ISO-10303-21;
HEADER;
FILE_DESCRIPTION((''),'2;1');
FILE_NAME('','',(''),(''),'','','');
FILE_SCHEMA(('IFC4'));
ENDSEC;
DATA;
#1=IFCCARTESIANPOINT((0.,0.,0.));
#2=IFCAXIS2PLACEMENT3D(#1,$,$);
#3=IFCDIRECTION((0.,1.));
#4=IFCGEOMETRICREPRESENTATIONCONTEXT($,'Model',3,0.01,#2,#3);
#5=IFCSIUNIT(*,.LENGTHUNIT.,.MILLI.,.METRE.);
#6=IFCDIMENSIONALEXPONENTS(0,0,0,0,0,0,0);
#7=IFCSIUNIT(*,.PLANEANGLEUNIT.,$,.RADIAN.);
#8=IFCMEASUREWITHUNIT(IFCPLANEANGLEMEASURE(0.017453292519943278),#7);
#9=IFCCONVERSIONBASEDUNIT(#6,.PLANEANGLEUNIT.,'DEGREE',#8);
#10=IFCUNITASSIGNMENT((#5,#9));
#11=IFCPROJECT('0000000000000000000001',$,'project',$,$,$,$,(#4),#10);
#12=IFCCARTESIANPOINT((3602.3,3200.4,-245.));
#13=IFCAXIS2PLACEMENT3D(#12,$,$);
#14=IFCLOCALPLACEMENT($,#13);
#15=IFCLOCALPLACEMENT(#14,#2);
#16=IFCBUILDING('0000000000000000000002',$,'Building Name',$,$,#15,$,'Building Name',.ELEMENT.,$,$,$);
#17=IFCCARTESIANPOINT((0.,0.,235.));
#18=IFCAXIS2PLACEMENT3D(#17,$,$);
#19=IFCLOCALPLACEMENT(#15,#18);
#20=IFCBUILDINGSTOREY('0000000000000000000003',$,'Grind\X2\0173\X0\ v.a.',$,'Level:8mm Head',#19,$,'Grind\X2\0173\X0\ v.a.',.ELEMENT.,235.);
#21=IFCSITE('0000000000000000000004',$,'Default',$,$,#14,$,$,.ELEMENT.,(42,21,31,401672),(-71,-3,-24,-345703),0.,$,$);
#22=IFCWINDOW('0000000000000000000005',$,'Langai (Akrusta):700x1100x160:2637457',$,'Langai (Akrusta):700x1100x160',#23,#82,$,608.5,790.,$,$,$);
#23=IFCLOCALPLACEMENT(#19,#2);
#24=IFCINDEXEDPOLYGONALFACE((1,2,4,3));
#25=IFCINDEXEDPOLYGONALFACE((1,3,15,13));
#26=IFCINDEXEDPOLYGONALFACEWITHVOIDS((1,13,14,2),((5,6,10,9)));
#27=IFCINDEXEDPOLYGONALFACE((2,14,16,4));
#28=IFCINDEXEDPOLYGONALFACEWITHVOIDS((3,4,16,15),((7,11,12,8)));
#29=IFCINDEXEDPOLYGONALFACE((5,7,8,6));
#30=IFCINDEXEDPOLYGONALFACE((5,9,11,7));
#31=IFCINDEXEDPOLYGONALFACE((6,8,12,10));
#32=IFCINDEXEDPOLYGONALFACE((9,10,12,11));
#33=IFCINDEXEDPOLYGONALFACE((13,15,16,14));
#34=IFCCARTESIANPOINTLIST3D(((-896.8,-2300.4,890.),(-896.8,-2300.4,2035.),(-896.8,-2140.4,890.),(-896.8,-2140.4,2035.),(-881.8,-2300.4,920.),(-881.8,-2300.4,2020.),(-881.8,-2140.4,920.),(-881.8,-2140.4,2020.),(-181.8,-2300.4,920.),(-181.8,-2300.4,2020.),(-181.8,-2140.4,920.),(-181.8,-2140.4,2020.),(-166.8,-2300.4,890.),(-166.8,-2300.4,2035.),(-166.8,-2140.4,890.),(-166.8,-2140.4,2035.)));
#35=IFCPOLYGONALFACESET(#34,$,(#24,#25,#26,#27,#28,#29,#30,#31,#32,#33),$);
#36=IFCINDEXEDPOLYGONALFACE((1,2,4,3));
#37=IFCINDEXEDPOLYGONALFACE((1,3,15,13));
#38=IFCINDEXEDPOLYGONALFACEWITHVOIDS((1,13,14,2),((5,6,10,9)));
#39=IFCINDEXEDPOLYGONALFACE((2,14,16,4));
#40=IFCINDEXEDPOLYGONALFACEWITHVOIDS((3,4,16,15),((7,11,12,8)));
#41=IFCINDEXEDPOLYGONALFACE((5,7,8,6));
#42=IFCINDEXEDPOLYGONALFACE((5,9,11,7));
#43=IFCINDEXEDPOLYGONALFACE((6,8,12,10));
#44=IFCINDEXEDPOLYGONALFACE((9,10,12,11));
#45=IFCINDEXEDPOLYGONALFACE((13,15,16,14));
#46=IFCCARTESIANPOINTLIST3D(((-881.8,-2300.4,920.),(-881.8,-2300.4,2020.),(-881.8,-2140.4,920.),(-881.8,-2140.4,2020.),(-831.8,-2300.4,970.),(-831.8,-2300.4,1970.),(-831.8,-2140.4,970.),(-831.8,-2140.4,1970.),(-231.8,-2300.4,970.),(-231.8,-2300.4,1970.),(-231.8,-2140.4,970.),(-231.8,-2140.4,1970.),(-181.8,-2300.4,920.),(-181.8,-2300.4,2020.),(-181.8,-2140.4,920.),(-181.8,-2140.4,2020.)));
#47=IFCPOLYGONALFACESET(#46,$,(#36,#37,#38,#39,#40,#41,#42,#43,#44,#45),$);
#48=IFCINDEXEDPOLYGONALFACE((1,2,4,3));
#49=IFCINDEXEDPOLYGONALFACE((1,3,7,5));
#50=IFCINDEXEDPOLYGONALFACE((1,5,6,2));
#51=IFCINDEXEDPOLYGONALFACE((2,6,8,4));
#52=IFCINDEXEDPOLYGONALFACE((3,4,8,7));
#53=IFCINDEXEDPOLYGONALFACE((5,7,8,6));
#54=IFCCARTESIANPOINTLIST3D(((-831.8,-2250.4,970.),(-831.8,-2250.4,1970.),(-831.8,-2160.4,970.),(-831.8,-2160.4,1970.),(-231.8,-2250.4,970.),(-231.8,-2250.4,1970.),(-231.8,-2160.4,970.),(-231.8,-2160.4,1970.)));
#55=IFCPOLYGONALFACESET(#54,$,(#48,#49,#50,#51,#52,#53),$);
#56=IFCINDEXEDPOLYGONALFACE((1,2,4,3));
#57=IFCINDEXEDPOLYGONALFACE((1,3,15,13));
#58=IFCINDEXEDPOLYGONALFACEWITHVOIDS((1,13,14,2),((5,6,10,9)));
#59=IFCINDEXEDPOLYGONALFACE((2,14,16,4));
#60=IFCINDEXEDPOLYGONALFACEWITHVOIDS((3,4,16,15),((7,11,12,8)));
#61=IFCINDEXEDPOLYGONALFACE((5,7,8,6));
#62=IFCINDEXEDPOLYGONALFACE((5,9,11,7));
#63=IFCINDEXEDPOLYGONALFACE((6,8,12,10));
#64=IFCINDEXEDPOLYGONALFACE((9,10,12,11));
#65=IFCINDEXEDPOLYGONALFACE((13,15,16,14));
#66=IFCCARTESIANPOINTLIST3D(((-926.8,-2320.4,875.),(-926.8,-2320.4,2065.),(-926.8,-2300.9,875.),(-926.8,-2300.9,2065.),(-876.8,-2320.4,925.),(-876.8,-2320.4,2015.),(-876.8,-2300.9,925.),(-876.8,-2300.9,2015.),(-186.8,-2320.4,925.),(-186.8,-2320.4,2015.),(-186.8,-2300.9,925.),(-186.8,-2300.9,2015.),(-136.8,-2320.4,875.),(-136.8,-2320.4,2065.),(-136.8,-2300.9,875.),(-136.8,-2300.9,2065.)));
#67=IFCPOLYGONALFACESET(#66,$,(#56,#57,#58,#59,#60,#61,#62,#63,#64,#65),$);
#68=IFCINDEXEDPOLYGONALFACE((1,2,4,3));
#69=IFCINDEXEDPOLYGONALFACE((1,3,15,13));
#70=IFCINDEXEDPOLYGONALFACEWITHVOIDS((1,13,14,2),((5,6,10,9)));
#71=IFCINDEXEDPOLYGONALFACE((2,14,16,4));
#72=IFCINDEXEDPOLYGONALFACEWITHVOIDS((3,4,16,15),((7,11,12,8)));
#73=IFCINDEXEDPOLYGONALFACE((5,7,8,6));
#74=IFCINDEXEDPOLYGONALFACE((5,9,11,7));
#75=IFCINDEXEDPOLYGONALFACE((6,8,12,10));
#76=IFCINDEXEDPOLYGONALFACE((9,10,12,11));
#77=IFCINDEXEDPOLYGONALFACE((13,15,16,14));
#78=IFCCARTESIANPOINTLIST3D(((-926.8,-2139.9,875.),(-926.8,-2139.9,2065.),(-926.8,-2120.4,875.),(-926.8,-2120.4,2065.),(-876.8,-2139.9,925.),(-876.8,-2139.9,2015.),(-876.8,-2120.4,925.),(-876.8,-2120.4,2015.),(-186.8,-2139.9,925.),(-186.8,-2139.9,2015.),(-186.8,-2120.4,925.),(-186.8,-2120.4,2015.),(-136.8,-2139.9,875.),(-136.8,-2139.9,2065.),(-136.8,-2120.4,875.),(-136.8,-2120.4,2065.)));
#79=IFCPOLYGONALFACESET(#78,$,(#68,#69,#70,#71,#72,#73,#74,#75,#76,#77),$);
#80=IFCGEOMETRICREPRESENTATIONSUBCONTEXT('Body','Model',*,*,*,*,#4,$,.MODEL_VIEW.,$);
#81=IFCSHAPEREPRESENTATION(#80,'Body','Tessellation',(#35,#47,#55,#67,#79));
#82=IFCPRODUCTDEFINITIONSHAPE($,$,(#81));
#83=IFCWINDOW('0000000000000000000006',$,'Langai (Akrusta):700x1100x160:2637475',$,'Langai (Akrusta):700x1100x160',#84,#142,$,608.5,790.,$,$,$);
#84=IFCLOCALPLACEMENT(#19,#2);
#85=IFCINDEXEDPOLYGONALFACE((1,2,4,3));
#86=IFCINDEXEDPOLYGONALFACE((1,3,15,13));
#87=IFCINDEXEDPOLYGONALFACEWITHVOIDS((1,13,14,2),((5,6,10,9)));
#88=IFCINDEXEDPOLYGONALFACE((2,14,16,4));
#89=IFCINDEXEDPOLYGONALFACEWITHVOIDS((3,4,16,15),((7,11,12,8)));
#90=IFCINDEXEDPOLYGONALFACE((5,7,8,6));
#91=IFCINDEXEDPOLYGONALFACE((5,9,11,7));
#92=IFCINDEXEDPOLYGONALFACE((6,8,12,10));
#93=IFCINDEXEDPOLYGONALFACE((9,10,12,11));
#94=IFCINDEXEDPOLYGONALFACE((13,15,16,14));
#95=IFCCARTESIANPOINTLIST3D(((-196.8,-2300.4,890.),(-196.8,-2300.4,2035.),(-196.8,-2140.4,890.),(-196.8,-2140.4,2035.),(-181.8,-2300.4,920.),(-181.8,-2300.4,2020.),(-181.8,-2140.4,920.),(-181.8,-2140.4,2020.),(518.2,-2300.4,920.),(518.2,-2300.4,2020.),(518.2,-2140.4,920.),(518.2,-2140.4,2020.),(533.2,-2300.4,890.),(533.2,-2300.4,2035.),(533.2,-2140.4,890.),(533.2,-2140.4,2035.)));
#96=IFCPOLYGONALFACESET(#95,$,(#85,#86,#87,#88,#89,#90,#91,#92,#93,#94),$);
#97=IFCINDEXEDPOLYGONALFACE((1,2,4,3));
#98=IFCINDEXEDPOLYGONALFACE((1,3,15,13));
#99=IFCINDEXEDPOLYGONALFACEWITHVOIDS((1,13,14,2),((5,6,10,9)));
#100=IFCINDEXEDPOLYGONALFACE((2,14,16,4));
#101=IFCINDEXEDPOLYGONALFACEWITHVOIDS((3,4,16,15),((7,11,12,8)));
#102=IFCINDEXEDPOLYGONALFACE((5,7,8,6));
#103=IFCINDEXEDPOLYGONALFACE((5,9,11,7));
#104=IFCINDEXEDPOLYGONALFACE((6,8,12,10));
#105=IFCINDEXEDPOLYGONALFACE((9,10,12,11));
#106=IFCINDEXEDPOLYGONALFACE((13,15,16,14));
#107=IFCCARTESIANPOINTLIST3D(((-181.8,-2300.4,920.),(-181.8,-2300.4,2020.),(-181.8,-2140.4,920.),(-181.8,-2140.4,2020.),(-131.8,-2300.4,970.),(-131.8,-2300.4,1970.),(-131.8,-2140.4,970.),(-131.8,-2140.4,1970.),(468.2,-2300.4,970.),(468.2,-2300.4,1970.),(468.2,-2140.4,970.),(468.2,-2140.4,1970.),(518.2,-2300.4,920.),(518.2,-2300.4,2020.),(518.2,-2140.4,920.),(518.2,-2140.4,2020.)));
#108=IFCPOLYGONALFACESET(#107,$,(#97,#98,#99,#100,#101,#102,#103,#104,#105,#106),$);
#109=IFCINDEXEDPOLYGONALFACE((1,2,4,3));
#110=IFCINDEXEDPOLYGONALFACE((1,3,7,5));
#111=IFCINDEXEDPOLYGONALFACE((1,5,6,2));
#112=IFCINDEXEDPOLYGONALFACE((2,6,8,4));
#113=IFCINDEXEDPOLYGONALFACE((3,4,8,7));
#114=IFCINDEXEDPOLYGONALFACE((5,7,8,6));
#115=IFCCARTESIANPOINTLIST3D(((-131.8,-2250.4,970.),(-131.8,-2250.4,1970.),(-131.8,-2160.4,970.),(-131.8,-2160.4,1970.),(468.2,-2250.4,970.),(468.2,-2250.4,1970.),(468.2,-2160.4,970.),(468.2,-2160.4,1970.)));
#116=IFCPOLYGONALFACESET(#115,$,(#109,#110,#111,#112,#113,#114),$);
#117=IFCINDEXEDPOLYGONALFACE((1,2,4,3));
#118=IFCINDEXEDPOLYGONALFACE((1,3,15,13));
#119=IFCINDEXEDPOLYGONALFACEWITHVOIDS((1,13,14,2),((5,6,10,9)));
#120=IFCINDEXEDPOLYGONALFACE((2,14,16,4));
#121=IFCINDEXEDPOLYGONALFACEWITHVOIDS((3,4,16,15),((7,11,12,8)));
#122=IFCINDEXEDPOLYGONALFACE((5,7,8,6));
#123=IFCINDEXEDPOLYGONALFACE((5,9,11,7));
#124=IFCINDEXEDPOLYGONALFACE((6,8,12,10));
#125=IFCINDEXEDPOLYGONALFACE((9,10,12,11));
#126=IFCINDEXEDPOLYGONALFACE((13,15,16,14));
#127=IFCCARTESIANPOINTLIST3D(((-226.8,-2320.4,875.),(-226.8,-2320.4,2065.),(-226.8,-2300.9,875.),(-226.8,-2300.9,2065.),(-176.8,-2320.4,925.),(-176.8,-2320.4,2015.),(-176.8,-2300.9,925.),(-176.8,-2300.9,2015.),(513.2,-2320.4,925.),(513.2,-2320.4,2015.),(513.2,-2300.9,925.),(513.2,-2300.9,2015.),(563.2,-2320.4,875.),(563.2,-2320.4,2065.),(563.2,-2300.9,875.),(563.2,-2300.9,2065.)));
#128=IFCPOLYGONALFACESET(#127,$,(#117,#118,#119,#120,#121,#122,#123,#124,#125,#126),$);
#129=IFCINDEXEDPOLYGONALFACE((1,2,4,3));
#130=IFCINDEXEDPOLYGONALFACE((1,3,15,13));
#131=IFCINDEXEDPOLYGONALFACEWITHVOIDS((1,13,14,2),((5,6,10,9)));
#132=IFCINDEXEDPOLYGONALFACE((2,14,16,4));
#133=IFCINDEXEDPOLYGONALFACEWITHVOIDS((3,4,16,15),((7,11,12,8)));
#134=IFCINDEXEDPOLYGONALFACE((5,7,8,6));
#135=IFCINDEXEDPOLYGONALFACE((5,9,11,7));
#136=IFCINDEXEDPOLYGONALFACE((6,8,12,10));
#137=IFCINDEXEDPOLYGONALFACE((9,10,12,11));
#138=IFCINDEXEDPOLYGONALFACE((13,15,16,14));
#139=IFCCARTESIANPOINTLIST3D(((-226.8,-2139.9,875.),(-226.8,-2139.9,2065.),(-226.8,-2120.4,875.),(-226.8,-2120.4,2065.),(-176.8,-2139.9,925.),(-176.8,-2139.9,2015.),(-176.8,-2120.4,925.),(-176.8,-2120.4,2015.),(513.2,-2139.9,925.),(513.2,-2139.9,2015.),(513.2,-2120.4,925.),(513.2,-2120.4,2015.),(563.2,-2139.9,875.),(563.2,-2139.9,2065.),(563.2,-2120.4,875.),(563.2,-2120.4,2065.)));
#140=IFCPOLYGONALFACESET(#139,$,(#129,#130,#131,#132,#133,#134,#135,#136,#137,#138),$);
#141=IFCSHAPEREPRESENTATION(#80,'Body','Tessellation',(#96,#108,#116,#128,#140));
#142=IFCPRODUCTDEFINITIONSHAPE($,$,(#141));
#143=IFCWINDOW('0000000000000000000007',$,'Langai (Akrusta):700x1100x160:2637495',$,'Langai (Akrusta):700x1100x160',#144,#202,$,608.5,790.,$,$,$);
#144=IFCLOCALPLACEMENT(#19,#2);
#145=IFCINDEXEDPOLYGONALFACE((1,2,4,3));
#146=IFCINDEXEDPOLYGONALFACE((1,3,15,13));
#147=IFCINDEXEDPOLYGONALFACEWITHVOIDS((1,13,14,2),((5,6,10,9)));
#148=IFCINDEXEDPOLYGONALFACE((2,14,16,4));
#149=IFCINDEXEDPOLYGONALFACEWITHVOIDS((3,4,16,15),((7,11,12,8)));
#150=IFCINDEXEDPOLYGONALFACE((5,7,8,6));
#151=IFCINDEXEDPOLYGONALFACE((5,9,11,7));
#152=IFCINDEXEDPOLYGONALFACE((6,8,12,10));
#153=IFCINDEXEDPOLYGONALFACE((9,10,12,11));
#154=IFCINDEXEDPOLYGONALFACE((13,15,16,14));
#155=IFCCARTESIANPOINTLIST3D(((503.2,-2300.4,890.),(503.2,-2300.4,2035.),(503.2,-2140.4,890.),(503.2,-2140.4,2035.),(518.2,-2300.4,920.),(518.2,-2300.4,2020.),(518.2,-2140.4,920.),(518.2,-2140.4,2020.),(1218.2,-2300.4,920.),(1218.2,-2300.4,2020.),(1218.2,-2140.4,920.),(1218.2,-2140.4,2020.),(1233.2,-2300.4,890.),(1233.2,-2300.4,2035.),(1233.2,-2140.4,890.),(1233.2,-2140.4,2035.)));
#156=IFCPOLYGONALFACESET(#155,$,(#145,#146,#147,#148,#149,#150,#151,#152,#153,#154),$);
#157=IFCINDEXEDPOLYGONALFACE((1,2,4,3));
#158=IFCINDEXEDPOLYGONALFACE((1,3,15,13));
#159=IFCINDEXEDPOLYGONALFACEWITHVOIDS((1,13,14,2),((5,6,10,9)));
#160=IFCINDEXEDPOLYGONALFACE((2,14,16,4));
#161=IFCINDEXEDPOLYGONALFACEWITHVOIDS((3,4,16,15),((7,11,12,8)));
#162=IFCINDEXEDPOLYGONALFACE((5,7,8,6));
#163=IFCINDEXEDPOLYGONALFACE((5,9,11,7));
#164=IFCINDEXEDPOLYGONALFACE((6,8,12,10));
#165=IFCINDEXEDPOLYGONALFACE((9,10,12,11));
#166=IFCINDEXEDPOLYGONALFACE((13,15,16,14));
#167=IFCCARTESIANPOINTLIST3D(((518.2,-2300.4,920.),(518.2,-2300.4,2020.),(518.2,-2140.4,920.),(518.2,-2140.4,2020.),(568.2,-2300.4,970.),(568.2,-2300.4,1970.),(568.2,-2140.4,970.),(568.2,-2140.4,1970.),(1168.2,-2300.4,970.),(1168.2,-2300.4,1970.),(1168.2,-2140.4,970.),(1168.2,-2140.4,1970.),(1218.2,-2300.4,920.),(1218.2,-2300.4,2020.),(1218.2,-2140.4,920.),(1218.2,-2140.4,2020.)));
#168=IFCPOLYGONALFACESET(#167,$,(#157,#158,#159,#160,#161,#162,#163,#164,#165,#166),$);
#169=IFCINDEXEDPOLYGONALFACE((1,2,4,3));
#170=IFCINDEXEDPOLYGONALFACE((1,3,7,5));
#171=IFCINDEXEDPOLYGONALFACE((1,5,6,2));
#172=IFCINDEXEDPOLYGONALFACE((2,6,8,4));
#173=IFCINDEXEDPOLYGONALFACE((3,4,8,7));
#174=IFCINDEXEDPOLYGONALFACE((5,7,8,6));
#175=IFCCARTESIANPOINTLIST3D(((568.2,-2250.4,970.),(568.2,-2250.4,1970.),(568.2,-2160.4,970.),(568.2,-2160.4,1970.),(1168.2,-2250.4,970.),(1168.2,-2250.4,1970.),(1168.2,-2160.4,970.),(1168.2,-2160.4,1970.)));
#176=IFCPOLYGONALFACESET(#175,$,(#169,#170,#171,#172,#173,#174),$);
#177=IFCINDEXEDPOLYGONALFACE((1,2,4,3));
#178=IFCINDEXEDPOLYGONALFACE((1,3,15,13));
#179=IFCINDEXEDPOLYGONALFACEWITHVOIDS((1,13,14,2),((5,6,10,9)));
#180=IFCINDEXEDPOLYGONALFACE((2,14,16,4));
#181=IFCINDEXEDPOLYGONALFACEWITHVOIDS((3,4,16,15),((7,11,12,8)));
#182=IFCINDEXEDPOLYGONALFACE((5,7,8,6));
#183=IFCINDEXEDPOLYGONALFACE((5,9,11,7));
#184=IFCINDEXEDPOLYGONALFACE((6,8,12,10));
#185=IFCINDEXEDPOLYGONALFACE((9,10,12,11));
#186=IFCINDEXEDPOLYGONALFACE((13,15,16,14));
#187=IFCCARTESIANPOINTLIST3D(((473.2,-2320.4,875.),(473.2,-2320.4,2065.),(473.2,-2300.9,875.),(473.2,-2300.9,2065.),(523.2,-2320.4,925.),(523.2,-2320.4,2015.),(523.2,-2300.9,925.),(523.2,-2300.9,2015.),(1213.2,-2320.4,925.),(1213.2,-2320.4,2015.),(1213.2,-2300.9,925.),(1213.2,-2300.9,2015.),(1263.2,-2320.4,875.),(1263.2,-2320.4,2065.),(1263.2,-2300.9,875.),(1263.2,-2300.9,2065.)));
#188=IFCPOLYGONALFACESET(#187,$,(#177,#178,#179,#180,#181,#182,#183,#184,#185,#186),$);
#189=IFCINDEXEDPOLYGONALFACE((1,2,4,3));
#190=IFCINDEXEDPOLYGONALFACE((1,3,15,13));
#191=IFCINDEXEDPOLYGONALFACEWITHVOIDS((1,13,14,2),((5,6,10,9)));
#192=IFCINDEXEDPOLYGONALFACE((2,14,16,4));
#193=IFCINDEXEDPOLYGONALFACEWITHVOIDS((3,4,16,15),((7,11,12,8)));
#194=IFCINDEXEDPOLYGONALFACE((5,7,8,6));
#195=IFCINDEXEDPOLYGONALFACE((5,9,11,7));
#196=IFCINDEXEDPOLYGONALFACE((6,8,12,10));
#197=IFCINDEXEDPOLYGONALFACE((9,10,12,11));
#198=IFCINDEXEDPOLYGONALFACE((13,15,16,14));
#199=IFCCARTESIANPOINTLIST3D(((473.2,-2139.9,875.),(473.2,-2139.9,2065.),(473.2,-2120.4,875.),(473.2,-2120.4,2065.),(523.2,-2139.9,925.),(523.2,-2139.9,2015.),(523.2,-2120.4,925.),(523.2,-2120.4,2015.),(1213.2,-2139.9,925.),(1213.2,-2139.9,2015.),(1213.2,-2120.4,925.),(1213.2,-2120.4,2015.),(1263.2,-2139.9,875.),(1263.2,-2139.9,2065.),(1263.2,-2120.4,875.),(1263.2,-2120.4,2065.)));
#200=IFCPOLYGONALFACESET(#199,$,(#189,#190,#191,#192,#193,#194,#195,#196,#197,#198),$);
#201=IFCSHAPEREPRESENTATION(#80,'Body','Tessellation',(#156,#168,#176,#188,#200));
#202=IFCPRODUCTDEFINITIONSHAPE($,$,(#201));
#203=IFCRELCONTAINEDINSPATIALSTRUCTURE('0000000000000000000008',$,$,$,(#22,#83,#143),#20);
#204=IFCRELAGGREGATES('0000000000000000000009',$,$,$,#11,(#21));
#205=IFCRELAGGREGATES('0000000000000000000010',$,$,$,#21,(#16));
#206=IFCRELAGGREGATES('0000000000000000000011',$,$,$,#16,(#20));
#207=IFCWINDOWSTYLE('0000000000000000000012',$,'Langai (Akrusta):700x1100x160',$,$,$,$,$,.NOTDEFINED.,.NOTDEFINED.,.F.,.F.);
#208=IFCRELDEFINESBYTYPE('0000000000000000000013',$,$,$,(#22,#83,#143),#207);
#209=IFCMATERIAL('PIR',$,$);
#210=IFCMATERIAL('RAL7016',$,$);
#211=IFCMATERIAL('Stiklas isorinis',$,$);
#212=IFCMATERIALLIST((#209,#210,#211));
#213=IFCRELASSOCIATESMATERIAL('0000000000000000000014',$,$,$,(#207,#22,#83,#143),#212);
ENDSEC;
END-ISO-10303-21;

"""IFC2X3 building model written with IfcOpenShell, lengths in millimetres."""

from ifc_helpers import new_model, entity, si_unit, converted_unit, direction, frame, frame_2d, origin, place, context, subcontext, project, spatial, polyline, rectangle, outline, extrude, source, transform, mapped, material, material_list, type_object, type_shapes, element, save


model = new_model("IFC2X3")

# Units and contexts
model_context = context("Model", 3, precision=0.01, world=origin(), true_north=direction((0.0, 1.0)))
body_context = subcontext(model_context, "Body", "Model", "MODEL_VIEW")
ifc_project = project(units=[si_unit("LENGTHUNIT", "METRE", prefix="MILLI"), converted_unit("PLANEANGLEUNIT", "DEGREE", entity("IfcPlaneAngleMeasure", 0.017453292519943278), si_unit("PLANEANGLEUNIT", "RADIAN"), dimensions=[0, 0, 0, 0, 0, 0, 0])], contexts=[model_context])

# Site, building, storey
site_placement = place(None, frame((3602.3, 3200.4, -245.0)))
site = spatial("IfcSite", under=ifc_project, at=site_placement, Name="Default", CompositionType="ELEMENT", RefLatitude=(42, 21, 31, 401672), RefLongitude=(-71, -3, -24, -345703), RefElevation=0.0)
building_placement = place(site_placement, origin())
building = spatial("IfcBuilding", under=site, at=building_placement, Name="Building Name", LongName="Building Name", CompositionType="ELEMENT")
storey_placement = place(building_placement, frame((0.0, 0.0, 235.0)))
storey = spatial("IfcBuildingStorey", under=building, at=storey_placement, Name="Grindų v.a.", ObjectType="Level:8mm Head", LongName="Grindų v.a.", CompositionType="ELEMENT", Elevation=235.0)

# Shared definitions
ifc_material_1 = material(Name="PIR")

# Shared definitions
ifc_material_2 = material(Name="RAL7016")

# Windows
ifc_material_3 = material(Name="Stiklas isorinis")
ifc_material_list_1 = material_list([ifc_material_1, ifc_material_2, ifc_material_3])
window_style = type_object("IfcWindowStyle", Name="Langai (Akrusta):700x1100x160", ConstructionType="NOTDEFINED", OperationType="NOTDEFINED", ParameterTakesPrecedence=False, Sizeable=False, material=ifc_material_list_1)
shared_shape_1 = source(origin(), body_context, "Body", "SweptSolid", [
    extrude(outline(polyline([(-572.5, -365.0), (572.5, -365.0), (572.5, 365.0), (-572.5, 365.0), (-572.5, -365.0)]), holes=[polyline([(557.5, 350.0), (557.5, -350.0), (-542.5, -350.0), (-542.5, 350.0), (557.5, 350.0)])]), frame((0.0, 0.0, 1462.5), z_axis=(0.0, 1.0, 0.0), x_axis=(0.0, 0.0, 1.0)), (0.0, 0.0, 1.0), 160.0),
    extrude(outline(polyline([(-550.0, -350.0), (550.0, -350.0), (550.0, 350.0), (-550.0, 350.0), (-550.0, -350.0)]), holes=[polyline([(-500.0, 300.0), (500.0, 300.0), (500.0, -300.0), (-500.0, -300.0), (-500.0, 300.0)])]), frame((0.0, 0.0, 1470.0), z_axis=(0.0, 1.0, 0.0), x_axis=(0.0, 0.0, 1.0)), (0.0, 0.0, 1.0), 160.0),
    extrude(rectangle(XDim=90.0, YDim=600.0, at=frame_2d((0.0, 0.0), x_axis=(1.0, 0.0))), frame((0.0, 95.0, 970.0), z_axis=(0.0, 0.0, 1.0), x_axis=(0.0, 1.0, 0.0)), (0.0, 0.0, 1.0), 1000.0),
    extrude(outline(polyline([(-395.0, -595.0), (395.0, -595.0), (395.0, 595.0), (-395.0, 595.0), (-395.0, -595.0)]), holes=[polyline([(-345.0, 545.0), (345.0, 545.0), (345.0, -545.0), (-345.0, -545.0), (-345.0, 545.0)])]), frame((0.0, -20.0, 1470.0), z_axis=(0.0, 1.0, 0.0), x_axis=(1.0, 0.0, 0.0)), (0.0, 0.0, 1.0), 19.5),
    extrude(outline(polyline([(-395.0, -595.0), (395.0, -595.0), (395.0, 595.0), (-395.0, 595.0), (-395.0, -595.0)]), holes=[polyline([(-345.0, 545.0), (345.0, 545.0), (345.0, -545.0), (-345.0, -545.0), (-345.0, 545.0)])]), frame((0.0, 160.5, 1470.0), z_axis=(0.0, 1.0, 0.0), x_axis=(1.0, 0.0, 0.0)), (0.0, 0.0, 1.0), 19.5),
])
type_shapes(window_style, [shared_shape_1])
for number, where, name in (
    (1, (-531.8, -2300.4, 0.0), "Langai (Akrusta):700x1100x160:2637457"),
    (2, (168.2, -2300.4, 0.0), "Langai (Akrusta):700x1100x160:2637475"),
    (3, (868.2, -2300.4, 0.0), "Langai (Akrusta):700x1100x160:2637495"),
):
    element("IfcWindow", number, at=place(storey_placement, frame(where)), inside=storey, type_object=window_style, material=ifc_material_list_1, Name=name, ObjectType="Langai (Akrusta):700x1100x160", OverallHeight=608.5, OverallWidth=790.0, context=body_context, shape_type="MappedRepresentation", body=[
        mapped(shared_shape_1, transform((0.0, 0.0, 0.0), scale=1.0)),
    ])

save(model, "model.ifc")
